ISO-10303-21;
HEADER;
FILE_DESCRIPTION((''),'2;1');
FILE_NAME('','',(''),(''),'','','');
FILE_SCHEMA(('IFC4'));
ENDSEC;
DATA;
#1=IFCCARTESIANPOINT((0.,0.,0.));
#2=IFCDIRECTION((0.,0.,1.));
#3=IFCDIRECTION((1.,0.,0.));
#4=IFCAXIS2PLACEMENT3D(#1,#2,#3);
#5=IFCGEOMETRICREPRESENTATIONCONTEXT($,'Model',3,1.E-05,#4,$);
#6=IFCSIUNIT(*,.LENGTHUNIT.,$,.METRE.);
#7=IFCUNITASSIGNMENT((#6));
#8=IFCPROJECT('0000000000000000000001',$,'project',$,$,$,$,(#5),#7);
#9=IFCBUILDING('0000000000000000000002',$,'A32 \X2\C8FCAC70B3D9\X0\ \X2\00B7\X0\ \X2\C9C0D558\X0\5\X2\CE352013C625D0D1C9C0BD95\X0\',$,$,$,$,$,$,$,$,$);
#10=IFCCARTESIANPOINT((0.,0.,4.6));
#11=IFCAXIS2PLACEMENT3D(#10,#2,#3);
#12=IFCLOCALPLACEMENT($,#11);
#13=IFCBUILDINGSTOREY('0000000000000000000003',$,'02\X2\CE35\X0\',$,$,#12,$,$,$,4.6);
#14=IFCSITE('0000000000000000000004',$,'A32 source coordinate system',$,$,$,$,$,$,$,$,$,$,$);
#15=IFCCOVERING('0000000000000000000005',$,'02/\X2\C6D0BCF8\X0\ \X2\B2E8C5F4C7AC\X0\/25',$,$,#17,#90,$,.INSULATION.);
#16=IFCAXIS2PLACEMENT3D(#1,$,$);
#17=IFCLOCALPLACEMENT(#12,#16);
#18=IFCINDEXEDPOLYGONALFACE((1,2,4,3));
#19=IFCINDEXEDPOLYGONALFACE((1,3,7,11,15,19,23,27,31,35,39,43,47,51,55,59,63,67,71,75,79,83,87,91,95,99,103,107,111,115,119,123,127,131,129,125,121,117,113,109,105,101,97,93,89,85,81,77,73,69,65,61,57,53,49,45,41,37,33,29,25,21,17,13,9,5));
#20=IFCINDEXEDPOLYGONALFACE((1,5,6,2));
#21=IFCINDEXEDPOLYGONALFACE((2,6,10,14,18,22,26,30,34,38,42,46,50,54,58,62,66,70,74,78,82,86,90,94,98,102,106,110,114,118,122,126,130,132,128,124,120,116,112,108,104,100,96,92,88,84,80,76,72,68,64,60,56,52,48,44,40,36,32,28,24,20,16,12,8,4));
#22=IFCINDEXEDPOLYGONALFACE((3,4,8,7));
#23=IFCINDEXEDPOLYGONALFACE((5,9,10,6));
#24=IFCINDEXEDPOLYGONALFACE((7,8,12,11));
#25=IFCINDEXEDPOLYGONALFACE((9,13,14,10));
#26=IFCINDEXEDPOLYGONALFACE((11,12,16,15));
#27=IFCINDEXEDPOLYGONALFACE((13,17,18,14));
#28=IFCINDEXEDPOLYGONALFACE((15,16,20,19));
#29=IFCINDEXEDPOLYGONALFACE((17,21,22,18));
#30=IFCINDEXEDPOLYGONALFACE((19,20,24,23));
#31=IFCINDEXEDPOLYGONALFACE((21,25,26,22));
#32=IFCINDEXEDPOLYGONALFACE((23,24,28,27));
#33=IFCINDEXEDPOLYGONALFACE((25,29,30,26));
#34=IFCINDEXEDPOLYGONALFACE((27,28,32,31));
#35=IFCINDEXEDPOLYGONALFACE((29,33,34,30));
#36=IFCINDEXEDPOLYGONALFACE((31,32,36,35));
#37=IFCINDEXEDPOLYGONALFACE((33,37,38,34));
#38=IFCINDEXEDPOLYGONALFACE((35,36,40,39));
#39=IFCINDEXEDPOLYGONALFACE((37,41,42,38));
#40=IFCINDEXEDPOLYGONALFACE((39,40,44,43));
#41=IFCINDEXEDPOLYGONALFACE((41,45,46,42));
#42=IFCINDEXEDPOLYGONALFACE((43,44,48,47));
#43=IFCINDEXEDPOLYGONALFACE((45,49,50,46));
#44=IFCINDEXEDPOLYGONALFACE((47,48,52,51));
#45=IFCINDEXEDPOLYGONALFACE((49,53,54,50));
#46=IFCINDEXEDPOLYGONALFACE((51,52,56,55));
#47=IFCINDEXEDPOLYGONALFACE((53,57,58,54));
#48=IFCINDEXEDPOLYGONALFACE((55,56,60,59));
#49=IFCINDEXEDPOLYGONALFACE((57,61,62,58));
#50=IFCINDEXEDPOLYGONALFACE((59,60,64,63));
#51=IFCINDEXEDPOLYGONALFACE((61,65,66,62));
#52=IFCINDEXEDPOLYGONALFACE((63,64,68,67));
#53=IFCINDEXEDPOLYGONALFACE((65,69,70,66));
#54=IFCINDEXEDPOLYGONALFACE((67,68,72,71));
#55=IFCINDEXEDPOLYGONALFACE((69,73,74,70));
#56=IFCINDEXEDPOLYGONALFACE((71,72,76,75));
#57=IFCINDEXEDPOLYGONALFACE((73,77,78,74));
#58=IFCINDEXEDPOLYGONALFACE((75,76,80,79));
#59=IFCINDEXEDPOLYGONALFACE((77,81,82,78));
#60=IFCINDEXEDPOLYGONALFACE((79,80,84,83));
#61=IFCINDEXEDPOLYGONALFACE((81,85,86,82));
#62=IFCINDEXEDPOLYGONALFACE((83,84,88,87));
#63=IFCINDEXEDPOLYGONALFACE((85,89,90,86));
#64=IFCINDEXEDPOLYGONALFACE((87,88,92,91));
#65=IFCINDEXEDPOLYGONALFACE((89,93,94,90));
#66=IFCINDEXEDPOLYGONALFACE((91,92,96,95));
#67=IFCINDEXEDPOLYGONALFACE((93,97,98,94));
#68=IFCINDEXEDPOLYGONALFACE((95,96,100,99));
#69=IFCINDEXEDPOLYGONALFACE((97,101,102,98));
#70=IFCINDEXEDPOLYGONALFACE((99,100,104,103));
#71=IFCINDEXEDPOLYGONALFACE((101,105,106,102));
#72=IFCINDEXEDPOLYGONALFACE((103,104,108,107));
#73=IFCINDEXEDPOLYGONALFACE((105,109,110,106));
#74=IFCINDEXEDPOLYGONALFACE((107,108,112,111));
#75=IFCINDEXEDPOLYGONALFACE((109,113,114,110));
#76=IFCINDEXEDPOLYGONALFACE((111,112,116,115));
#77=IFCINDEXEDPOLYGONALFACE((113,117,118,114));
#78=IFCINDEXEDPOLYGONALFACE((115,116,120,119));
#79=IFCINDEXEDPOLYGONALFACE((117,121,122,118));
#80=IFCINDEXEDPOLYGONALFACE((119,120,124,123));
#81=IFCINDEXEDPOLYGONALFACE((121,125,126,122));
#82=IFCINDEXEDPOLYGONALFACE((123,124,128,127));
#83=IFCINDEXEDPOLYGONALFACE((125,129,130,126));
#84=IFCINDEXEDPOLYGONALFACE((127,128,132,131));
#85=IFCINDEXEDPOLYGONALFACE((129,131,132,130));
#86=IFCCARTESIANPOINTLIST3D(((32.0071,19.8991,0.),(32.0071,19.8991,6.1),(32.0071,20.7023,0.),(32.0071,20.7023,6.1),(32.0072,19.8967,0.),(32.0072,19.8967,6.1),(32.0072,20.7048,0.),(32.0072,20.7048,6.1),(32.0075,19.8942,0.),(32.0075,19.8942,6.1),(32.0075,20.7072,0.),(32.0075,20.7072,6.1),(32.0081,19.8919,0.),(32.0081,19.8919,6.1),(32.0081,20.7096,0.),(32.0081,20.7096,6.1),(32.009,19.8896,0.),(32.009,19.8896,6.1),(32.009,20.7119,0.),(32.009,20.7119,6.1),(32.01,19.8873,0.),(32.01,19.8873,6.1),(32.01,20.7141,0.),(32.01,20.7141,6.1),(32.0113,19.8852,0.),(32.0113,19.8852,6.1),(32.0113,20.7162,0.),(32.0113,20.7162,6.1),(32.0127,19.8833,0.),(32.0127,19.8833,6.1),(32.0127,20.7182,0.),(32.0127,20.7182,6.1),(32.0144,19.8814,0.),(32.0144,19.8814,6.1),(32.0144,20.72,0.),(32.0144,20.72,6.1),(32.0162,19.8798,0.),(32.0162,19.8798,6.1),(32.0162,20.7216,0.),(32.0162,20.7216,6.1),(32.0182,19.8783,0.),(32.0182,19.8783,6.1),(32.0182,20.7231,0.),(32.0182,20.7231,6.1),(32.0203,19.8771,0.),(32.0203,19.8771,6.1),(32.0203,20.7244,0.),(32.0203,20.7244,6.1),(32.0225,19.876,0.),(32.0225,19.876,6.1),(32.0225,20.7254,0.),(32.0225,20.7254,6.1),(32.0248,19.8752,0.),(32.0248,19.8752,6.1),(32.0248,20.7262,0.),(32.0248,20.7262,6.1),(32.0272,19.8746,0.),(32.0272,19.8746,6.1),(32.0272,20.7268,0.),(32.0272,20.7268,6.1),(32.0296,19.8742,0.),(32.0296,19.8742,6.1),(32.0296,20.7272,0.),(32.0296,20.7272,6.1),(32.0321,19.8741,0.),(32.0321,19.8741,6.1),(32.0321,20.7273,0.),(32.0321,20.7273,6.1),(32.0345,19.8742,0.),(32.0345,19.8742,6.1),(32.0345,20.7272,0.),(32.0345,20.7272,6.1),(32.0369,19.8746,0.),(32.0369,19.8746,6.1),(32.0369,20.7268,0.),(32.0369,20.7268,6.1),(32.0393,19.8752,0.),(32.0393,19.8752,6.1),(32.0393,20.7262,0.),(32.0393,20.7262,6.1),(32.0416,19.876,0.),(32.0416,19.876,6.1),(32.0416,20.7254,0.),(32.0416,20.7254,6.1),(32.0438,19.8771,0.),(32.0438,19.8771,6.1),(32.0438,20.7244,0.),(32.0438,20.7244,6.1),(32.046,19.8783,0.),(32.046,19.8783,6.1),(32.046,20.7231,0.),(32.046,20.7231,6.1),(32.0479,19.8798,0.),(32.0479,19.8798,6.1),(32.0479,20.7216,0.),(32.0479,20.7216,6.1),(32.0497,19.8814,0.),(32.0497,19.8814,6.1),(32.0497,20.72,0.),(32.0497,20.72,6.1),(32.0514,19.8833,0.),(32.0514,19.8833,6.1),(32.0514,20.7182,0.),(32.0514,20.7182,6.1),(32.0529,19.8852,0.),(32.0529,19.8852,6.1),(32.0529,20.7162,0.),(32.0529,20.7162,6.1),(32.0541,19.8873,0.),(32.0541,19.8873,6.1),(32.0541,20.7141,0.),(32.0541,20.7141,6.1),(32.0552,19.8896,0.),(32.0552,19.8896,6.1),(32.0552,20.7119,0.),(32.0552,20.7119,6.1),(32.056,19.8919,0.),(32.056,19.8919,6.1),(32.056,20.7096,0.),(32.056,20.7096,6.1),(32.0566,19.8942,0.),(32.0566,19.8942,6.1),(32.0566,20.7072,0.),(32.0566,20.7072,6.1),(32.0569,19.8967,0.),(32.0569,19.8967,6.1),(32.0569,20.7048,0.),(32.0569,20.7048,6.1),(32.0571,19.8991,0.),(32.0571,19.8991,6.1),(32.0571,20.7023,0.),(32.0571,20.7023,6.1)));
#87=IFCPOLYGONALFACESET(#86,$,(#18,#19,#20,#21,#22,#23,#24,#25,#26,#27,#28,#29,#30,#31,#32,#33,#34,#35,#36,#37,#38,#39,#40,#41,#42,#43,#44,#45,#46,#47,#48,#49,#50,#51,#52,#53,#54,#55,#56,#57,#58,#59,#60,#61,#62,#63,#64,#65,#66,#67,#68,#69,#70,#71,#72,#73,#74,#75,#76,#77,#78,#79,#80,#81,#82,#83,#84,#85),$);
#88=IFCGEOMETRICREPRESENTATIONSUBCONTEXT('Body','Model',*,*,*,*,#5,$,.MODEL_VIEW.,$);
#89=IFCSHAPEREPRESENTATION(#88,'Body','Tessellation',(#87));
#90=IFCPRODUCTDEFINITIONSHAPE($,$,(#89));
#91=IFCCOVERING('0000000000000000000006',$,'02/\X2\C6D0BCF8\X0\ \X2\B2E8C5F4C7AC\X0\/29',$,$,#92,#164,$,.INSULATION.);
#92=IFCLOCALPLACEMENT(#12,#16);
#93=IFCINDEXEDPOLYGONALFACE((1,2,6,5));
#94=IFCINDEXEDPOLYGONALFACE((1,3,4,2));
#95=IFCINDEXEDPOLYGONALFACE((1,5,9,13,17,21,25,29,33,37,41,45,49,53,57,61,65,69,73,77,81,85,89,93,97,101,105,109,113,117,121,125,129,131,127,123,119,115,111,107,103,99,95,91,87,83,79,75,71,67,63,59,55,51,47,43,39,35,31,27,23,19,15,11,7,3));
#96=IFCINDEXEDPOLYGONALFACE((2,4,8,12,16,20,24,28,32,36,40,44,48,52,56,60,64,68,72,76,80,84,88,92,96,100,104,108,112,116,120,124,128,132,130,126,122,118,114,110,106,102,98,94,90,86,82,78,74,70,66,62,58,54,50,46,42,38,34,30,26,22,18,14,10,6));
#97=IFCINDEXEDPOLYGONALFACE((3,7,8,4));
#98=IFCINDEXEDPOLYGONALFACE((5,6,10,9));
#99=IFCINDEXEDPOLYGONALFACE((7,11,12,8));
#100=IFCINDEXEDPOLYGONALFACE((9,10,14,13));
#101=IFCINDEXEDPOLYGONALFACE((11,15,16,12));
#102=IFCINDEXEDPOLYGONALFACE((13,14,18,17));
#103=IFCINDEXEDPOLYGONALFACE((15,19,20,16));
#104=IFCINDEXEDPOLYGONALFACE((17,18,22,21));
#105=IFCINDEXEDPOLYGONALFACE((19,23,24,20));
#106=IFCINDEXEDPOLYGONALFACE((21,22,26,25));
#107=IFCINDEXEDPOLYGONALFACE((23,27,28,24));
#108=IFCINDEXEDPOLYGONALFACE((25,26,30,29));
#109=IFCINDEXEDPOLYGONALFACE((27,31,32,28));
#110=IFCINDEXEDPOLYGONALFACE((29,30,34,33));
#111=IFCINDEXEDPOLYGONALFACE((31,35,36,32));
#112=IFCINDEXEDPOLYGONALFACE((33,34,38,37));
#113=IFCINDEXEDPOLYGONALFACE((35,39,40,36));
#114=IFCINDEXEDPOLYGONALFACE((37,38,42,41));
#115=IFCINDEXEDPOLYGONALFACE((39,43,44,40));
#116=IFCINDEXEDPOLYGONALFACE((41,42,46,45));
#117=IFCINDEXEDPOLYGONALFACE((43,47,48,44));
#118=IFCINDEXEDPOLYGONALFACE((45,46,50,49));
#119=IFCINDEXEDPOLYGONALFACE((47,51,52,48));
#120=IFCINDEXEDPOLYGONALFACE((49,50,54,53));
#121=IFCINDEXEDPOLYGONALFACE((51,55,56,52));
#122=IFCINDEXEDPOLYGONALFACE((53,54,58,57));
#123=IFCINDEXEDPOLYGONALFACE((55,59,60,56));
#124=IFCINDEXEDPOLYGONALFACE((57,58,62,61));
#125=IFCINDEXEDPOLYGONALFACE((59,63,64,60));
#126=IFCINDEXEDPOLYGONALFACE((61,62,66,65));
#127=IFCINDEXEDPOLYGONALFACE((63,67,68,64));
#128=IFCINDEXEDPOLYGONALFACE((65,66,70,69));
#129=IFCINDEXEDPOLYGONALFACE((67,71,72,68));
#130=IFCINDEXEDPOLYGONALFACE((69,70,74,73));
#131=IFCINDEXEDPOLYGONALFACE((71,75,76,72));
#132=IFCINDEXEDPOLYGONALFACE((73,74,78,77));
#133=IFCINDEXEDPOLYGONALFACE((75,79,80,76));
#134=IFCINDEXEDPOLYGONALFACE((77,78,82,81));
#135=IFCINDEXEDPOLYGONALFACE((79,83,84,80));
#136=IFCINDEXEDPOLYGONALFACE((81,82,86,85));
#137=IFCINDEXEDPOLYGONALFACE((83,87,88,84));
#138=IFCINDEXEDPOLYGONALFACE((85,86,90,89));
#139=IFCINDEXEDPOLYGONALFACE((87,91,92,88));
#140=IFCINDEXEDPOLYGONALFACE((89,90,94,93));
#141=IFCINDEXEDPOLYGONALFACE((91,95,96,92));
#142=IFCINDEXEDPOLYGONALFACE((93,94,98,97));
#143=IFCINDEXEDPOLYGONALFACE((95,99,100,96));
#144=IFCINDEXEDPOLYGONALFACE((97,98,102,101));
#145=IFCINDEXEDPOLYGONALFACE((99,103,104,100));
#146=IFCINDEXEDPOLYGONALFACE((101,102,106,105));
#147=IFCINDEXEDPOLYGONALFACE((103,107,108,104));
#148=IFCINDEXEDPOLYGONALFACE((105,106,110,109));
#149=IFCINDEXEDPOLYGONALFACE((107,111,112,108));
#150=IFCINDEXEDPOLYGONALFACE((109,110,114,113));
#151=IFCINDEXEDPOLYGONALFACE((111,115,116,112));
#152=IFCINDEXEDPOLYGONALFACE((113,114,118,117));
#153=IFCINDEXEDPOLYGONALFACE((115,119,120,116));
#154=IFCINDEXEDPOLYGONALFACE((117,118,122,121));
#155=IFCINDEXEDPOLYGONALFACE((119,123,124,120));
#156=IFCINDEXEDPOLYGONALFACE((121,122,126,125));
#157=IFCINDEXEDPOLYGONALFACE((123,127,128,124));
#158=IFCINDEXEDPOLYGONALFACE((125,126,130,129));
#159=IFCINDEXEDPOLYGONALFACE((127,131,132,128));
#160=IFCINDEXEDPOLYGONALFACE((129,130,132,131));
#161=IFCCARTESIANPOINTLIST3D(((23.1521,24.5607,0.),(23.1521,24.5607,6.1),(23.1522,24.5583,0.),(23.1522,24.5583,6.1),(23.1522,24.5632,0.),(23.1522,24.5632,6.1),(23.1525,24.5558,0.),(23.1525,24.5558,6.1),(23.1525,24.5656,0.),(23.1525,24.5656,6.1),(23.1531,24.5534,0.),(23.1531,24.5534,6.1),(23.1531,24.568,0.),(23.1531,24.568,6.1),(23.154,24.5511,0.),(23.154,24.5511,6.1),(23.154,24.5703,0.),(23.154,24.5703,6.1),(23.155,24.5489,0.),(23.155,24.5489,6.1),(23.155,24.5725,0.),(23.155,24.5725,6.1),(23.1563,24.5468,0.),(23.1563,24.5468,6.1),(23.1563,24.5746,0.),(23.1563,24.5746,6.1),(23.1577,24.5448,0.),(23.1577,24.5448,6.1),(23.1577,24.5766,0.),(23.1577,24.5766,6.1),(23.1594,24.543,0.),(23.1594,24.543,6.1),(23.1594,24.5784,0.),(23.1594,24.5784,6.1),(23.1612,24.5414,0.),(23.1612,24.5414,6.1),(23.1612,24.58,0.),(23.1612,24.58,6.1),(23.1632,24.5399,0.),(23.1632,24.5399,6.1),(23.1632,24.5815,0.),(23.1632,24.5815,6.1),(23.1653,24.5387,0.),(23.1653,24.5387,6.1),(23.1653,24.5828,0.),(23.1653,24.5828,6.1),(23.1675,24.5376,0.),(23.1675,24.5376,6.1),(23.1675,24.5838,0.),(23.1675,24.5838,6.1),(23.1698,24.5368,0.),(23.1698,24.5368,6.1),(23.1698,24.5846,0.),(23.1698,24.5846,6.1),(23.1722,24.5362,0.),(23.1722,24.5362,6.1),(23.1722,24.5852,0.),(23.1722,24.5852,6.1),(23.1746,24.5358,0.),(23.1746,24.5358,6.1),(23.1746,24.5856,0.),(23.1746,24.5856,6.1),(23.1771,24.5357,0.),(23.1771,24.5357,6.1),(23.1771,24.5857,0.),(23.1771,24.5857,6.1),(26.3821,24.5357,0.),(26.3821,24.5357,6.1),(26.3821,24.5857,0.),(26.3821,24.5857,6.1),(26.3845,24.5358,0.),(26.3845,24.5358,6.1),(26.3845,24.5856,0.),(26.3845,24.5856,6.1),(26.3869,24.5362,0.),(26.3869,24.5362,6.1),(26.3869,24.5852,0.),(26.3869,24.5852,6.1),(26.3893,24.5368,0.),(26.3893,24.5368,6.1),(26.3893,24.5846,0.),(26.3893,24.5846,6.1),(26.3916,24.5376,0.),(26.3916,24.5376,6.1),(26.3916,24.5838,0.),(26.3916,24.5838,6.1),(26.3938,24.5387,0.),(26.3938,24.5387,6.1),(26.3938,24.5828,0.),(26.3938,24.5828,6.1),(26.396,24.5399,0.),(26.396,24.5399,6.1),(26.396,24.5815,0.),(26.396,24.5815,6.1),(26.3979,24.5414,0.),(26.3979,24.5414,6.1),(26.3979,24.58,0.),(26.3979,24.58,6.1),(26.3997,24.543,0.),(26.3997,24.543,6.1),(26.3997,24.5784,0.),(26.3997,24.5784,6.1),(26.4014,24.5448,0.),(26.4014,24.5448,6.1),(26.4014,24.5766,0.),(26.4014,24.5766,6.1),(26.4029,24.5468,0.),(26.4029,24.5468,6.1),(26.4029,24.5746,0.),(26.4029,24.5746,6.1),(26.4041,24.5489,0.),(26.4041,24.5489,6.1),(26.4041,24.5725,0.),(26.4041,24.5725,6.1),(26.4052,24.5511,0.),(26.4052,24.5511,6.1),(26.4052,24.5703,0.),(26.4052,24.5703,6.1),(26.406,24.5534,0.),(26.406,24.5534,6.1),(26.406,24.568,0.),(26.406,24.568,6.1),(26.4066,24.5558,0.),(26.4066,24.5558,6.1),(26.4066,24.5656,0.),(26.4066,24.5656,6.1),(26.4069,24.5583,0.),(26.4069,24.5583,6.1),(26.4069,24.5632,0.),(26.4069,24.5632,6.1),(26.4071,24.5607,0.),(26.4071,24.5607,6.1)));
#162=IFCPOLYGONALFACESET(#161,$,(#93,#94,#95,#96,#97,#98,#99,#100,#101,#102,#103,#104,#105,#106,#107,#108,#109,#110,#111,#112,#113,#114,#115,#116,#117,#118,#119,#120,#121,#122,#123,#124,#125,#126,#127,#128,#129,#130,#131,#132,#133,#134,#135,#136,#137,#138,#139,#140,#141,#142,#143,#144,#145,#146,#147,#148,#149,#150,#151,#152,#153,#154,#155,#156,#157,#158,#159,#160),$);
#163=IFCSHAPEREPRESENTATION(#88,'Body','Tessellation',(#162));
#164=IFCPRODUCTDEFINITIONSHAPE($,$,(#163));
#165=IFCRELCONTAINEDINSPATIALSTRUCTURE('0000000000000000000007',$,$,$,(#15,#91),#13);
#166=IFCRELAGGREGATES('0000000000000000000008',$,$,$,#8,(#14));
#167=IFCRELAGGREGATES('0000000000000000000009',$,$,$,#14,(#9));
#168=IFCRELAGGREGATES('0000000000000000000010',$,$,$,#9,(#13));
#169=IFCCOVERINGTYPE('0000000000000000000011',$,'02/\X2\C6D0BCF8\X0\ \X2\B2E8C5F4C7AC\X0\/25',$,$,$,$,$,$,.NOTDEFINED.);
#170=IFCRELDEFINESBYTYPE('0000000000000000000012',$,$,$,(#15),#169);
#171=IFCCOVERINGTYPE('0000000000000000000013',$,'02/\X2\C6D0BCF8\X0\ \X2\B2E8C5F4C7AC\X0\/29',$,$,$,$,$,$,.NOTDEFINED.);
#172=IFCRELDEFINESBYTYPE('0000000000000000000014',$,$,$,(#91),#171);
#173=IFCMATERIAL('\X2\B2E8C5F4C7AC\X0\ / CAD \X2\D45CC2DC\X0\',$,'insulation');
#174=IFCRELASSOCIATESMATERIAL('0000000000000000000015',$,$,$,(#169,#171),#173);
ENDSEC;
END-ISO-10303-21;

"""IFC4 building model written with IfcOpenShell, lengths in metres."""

from ifc_helpers import new_model, si_unit, frame, origin, origin_with_axes, place, context, subcontext, project, spatial, polyline, outline, extrude, source, transform, mapped, material, type_object, type_shapes, element, save


model = new_model("IFC4")

# Units and contexts
model_context = context("Model", 3, precision=1e-05, world=origin_with_axes())
body_context = subcontext(model_context, "Body", "Model", "MODEL_VIEW")
ifc_project = project(units=[si_unit("LENGTHUNIT", "METRE")], contexts=[model_context])

# Site, building, storey
storey_placement = place(None, frame((0.0, 0.0, 4.6), z_axis=(0.0, 0.0, 1.0), x_axis=(1.0, 0.0, 0.0)))
site = spatial("IfcSite", under=ifc_project, Name="A32 source coordinate system")
building = spatial("IfcBuilding", under=site, Name="A32 주거동 · 지하5층–옥탑지붕")
storey = spatial("IfcBuildingStorey", under=building, at=storey_placement, Name="02층", Elevation=4.6)

# Coverings
ifc_material = material(Name="단열재 / CAD 표시", Category="insulation")
covering_type_1 = type_object("IfcCoveringType", Name="02/원본 단열재/25", PredefinedType="NOTDEFINED", material=ifc_material)
shared_shape_1 = source(origin(), body_context, "Body", "SweptSolid", [
    extrude(outline(polyline([(32.01, 20.7141), (32.0113, 20.7162), (32.0127, 20.7182), (32.0144, 20.72), (32.0162, 20.7216), (32.0182, 20.7231), (32.0203, 20.7244), (32.0225, 20.7254), (32.0248, 20.7262), (32.0272, 20.7268), (32.0296, 20.7272), (32.0321, 20.7273), (32.0345, 20.7272), (32.0369, 20.7268), (32.0393, 20.7262), (32.0416, 20.7254), (32.0438, 20.7244), (32.046, 20.7231), (32.0479, 20.7216), (32.0497, 20.72), (32.0514, 20.7182), (32.0529, 20.7162), (32.0541, 20.7141), (32.0552, 20.7119), (32.056, 20.7096), (32.0566, 20.7072), (32.0569, 20.7048), (32.0571, 20.7023), (32.0571, 19.8991), (32.0569, 19.8967), (32.0566, 19.8942), (32.056, 19.8919), (32.0552, 19.8896), (32.0541, 19.8873), (32.0529, 19.8852), (32.0514, 19.8833), (32.0497, 19.8814), (32.0479, 19.8798), (32.046, 19.8783), (32.0438, 19.8771), (32.0416, 19.876), (32.0393, 19.8752), (32.0369, 19.8746), (32.0345, 19.8742), (32.0321, 19.8741), (32.0296, 19.8742), (32.0272, 19.8746), (32.0248, 19.8752), (32.0225, 19.876), (32.0203, 19.8771), (32.0182, 19.8783), (32.0162, 19.8798), (32.0144, 19.8814), (32.0127, 19.8833), (32.0113, 19.8852), (32.01, 19.8873), (32.009, 19.8896), (32.0081, 19.8919), (32.0075, 19.8942), (32.0072, 19.8967), (32.0071, 19.8991), (32.0071, 20.7023), (32.0072, 20.7048), (32.0075, 20.7072), (32.0081, 20.7096), (32.009, 20.7119), (32.01, 20.7141)])), origin(), (0.0, 0.0, 1.0), 6.1),
])
type_shapes(covering_type_1, [shared_shape_1])
covering_1_placement = place(storey_placement, origin_with_axes())
element("IfcCovering", 1, at=covering_1_placement, inside=storey, type_object=covering_type_1, Name="02/원본 단열재/25", PredefinedType="INSULATION", context=body_context, shape_type="MappedRepresentation", body=[
    mapped(shared_shape_1, transform((0.0, 0.0, 0.0), scale=1.0)),
])
covering_type_2 = type_object("IfcCoveringType", Name="02/원본 단열재/29", PredefinedType="NOTDEFINED", material=ifc_material)
shared_shape_2 = source(origin(), body_context, "Body", "SweptSolid", [
    extrude(outline(polyline([(26.3938, 24.5828), (26.396, 24.5815), (26.3979, 24.58), (26.3997, 24.5784), (26.4014, 24.5766), (26.4029, 24.5746), (26.4041, 24.5725), (26.4052, 24.5703), (26.406, 24.568), (26.4066, 24.5656), (26.4069, 24.5632), (26.4071, 24.5607), (26.4069, 24.5583), (26.4066, 24.5558), (26.406, 24.5534), (26.4052, 24.5511), (26.4041, 24.5489), (26.4029, 24.5468), (26.4014, 24.5448), (26.3997, 24.543), (26.3979, 24.5414), (26.396, 24.5399), (26.3938, 24.5387), (26.3916, 24.5376), (26.3893, 24.5368), (26.3869, 24.5362), (26.3845, 24.5358), (26.3821, 24.5357), (23.1771, 24.5357), (23.1746, 24.5358), (23.1722, 24.5362), (23.1698, 24.5368), (23.1675, 24.5376), (23.1653, 24.5387), (23.1632, 24.5399), (23.1612, 24.5414), (23.1594, 24.543), (23.1577, 24.5448), (23.1563, 24.5468), (23.155, 24.5489), (23.154, 24.5511), (23.1531, 24.5534), (23.1525, 24.5558), (23.1522, 24.5583), (23.1521, 24.5607), (23.1522, 24.5632), (23.1525, 24.5656), (23.1531, 24.568), (23.154, 24.5703), (23.155, 24.5725), (23.1563, 24.5746), (23.1577, 24.5766), (23.1594, 24.5784), (23.1612, 24.58), (23.1632, 24.5815), (23.1653, 24.5828), (23.1675, 24.5838), (23.1698, 24.5846), (23.1722, 24.5852), (23.1746, 24.5856), (23.1771, 24.5857), (26.3821, 24.5857), (26.3845, 24.5856), (26.3869, 24.5852), (26.3893, 24.5846), (26.3916, 24.5838), (26.3938, 24.5828)])), origin(), (0.0, 0.0, 1.0), 6.1),
])
type_shapes(covering_type_2, [shared_shape_2])
covering_2_placement = place(storey_placement, origin_with_axes())
element("IfcCovering", 2, at=covering_2_placement, inside=storey, type_object=covering_type_2, Name="02/원본 단열재/29", PredefinedType="INSULATION", context=body_context, shape_type="MappedRepresentation", body=[
    mapped(shared_shape_2, transform((0.0, 0.0, 0.0), scale=1.0)),
])

save(model, "model.ifc")
